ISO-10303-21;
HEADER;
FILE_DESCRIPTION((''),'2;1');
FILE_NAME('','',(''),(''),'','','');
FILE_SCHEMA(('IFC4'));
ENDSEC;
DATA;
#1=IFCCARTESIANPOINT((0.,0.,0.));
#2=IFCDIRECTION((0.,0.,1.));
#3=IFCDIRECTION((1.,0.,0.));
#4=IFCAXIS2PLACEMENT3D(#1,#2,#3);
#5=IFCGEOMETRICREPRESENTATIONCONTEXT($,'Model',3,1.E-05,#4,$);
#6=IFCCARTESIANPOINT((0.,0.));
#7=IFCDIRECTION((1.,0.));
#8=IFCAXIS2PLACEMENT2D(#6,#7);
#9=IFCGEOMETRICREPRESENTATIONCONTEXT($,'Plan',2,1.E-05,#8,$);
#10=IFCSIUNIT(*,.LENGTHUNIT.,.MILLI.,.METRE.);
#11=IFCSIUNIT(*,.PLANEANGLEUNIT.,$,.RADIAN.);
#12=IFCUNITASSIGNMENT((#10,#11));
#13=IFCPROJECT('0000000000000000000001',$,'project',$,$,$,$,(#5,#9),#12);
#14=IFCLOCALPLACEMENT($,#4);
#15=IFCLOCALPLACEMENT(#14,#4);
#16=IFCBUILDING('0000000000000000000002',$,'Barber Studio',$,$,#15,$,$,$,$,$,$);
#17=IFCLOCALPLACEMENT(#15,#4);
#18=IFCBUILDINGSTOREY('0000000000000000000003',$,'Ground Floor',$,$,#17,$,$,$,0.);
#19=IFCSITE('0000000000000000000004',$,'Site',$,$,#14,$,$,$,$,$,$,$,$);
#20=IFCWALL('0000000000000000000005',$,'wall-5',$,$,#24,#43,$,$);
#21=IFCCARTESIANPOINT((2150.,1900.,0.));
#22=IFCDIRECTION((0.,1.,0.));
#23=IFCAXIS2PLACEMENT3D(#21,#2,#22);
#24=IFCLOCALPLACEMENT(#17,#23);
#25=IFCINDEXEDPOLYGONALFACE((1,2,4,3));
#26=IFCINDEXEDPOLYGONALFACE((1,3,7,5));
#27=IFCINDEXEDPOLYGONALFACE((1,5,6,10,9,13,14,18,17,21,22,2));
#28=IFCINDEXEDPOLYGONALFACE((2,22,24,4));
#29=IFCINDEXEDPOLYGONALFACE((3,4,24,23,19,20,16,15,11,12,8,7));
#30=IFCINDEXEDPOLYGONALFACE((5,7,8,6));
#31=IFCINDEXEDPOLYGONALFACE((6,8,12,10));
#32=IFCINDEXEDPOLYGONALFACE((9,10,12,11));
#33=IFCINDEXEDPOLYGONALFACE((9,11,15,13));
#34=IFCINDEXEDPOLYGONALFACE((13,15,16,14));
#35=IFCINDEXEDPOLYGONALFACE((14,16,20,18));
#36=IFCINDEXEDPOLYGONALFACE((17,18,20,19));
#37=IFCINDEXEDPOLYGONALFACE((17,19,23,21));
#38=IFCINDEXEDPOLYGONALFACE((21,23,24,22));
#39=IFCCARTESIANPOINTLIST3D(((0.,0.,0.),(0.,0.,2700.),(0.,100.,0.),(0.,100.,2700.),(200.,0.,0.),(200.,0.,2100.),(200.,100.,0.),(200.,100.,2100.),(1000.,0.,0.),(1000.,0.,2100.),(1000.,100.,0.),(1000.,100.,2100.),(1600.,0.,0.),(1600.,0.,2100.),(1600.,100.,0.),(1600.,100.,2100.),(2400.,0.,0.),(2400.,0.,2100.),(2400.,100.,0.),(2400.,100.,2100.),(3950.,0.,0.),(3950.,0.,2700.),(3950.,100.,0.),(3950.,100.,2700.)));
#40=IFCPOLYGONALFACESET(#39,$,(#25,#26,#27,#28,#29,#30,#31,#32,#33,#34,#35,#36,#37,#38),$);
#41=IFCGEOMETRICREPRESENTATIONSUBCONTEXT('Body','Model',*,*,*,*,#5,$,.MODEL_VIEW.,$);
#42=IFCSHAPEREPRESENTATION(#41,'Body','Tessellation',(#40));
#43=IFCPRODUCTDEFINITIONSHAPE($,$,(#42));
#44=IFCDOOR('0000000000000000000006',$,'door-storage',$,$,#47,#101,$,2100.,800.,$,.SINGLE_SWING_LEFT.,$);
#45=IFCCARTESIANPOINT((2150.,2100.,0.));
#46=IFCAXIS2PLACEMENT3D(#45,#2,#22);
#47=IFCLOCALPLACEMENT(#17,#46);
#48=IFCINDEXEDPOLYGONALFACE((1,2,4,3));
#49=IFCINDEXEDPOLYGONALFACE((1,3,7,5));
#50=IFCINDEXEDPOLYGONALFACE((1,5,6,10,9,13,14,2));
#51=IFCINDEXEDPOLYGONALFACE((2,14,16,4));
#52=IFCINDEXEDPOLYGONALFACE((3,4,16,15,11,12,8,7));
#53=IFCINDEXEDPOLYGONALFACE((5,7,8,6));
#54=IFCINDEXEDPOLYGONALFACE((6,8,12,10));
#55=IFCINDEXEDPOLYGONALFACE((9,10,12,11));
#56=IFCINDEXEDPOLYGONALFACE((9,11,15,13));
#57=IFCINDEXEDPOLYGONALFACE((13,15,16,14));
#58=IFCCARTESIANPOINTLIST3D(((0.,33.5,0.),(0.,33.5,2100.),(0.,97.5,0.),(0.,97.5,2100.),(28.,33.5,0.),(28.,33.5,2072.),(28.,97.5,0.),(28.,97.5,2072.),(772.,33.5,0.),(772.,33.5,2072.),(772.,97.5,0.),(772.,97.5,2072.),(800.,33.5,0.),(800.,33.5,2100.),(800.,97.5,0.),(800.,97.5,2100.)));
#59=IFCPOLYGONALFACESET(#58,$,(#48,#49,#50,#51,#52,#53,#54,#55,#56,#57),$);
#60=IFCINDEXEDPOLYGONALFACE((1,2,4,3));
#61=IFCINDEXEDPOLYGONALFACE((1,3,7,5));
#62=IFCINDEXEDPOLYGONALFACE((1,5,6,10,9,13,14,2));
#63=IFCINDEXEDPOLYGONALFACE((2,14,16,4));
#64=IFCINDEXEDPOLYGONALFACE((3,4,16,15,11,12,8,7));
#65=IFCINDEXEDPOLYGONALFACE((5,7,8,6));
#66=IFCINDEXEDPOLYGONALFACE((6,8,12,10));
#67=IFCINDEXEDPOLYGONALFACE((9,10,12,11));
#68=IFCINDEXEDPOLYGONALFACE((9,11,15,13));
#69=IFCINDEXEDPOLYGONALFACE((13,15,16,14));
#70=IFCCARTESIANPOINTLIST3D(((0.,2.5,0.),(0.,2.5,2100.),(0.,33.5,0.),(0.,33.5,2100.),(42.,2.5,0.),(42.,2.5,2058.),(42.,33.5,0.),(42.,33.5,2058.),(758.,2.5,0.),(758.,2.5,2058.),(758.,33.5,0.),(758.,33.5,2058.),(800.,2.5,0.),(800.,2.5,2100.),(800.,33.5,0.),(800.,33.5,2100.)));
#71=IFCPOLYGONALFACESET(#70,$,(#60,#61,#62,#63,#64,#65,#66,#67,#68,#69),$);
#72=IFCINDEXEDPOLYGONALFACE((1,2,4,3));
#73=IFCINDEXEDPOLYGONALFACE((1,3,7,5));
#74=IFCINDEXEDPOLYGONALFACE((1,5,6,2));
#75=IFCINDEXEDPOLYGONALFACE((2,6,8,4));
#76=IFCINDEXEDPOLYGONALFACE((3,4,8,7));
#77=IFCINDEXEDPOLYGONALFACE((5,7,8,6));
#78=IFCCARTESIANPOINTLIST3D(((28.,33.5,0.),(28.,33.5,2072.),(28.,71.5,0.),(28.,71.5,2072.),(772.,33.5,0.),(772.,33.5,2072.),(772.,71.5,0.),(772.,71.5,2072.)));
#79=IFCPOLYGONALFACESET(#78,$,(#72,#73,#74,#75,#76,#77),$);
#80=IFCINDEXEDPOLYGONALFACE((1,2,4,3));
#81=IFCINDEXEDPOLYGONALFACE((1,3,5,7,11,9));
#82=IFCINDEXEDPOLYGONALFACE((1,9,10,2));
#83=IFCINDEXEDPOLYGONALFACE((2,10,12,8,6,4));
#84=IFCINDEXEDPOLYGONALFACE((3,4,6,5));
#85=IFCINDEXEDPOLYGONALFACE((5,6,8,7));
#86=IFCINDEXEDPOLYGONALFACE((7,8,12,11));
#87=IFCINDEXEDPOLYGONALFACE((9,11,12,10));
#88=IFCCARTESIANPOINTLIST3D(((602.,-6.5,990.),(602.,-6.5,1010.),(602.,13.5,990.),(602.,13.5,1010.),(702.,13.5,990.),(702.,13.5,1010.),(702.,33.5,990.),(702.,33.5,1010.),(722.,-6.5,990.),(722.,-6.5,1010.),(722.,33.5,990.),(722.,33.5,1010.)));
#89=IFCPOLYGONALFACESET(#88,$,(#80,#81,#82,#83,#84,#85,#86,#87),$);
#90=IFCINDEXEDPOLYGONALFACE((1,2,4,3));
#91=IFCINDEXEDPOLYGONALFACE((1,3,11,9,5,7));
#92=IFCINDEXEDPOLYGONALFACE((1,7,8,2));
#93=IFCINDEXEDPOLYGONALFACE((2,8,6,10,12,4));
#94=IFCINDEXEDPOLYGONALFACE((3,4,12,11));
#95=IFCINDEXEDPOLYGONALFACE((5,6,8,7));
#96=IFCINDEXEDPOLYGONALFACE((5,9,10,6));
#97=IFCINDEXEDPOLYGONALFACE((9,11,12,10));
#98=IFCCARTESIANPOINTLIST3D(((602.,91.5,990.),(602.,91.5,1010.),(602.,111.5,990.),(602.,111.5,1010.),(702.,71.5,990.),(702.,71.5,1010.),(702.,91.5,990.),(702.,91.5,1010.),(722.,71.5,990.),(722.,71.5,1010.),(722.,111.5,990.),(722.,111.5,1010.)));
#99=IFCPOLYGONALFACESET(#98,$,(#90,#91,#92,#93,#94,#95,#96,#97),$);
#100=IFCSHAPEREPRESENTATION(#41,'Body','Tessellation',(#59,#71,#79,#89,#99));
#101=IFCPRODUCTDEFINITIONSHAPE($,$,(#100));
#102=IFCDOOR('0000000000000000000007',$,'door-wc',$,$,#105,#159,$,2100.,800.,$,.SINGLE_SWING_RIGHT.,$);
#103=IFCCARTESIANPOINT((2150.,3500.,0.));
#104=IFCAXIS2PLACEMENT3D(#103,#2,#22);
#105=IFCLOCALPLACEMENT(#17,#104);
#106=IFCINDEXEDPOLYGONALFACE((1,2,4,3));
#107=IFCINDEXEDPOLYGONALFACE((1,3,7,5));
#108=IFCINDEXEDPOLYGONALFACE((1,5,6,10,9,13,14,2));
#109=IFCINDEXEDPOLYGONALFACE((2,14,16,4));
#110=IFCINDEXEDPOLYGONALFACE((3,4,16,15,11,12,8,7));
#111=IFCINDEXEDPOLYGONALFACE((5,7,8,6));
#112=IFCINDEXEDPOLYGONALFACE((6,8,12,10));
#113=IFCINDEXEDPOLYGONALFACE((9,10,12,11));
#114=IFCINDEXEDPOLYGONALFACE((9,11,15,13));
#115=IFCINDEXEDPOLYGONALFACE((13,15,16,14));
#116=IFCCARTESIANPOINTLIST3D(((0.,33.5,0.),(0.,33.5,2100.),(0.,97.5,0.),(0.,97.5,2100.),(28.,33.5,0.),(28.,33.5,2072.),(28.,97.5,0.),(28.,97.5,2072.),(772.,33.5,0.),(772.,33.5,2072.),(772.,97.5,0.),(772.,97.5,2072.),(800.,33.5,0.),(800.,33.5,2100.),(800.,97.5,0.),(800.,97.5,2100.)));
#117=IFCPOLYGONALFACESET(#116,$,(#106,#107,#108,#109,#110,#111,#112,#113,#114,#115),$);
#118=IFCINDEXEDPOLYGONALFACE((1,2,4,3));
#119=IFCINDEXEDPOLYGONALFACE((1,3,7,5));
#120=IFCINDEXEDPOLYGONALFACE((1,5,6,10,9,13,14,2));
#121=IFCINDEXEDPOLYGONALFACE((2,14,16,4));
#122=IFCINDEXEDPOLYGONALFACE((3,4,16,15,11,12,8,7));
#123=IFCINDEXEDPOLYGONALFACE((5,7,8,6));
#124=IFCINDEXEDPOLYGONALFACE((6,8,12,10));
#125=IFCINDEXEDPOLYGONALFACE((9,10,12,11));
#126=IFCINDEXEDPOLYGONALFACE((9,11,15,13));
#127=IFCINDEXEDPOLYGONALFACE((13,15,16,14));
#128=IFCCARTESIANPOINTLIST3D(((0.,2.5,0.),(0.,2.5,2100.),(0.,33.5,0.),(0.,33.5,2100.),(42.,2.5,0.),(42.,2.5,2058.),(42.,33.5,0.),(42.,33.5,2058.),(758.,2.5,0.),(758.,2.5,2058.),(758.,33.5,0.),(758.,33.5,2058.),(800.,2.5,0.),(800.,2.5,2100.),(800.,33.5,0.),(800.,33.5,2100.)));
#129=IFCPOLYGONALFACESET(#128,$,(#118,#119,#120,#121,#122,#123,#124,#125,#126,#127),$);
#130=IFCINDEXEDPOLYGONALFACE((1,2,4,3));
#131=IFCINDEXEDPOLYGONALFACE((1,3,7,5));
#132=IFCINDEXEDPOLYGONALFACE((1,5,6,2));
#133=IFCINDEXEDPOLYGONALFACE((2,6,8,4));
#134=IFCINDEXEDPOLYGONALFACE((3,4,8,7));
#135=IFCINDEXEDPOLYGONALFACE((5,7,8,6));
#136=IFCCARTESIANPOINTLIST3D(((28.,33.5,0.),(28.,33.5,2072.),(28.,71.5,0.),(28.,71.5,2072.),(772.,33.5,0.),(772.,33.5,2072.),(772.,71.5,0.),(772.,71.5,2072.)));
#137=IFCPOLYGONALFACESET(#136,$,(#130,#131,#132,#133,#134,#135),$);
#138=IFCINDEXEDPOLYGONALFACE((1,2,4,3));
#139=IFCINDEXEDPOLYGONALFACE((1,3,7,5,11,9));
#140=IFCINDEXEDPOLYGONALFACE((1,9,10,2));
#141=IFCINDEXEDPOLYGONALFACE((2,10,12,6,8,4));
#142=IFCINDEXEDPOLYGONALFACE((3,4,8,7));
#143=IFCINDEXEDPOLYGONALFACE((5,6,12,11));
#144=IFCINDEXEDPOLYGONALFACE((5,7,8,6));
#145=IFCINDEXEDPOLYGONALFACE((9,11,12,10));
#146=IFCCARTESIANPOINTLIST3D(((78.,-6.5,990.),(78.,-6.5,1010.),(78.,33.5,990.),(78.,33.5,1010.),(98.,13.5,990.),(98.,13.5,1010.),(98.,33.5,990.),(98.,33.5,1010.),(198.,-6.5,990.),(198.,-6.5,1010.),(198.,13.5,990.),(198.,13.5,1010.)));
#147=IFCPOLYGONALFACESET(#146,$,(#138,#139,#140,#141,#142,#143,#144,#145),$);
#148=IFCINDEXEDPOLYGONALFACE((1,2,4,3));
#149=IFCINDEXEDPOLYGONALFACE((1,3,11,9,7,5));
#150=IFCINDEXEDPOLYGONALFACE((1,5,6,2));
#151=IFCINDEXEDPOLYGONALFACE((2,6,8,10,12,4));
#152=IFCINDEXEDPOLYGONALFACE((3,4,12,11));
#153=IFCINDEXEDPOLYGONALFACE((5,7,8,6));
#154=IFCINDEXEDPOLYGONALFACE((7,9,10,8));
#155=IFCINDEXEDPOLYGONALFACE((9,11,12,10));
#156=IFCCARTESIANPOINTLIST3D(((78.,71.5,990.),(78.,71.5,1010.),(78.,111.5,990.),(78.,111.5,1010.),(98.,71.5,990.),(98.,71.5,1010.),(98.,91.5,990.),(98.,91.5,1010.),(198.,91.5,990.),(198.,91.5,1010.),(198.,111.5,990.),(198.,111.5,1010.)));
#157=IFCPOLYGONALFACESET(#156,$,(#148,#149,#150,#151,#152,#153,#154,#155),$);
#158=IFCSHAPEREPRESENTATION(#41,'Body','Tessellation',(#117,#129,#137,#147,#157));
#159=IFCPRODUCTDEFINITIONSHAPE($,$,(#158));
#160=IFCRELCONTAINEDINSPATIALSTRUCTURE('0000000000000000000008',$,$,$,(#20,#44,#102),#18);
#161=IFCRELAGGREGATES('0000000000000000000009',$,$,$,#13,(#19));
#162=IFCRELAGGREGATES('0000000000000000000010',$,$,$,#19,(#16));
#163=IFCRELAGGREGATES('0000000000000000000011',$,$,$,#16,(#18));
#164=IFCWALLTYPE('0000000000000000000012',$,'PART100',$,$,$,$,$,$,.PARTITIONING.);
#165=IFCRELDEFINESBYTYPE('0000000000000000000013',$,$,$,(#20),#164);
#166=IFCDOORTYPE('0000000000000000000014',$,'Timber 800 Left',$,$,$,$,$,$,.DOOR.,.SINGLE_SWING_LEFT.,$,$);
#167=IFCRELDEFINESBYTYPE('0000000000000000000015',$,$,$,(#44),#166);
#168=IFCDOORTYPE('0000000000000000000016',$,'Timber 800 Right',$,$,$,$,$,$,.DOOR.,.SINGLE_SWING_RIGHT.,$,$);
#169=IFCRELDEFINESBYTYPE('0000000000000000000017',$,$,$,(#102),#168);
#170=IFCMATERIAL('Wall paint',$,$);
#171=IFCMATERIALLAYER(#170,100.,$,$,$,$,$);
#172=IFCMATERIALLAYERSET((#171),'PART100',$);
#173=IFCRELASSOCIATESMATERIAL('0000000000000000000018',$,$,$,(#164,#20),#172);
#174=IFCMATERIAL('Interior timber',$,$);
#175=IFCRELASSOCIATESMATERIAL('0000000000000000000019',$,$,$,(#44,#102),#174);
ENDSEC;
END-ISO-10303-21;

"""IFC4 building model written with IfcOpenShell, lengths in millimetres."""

from ifc_helpers import new_model, entity, si_unit, frame, origin_with_axes, origin_2d_with_axis, place, context, subcontext, project, spatial, line, indexed_curve, outline, extrude, shape, material, layer, layer_set, layer_usage, type_object, element, fill, save


model = new_model("IFC4")

# Units and contexts
model_context = context("Model", 3, precision=1e-05, world=origin_with_axes())
plan_context = context("Plan", 2, precision=1e-05, world=origin_2d_with_axis())
body_context_1 = subcontext(model_context, "Body", "Model", "MODEL_VIEW")
body_context_2 = subcontext(plan_context, "Body", "Plan", "PLAN_VIEW")
ifc_project = project(units=[si_unit("LENGTHUNIT", "METRE", prefix="MILLI"), si_unit("PLANEANGLEUNIT", "RADIAN")], contexts=[model_context, plan_context])

# Site, building, storey
site_placement = place(None, origin_with_axes())
site = spatial("IfcSite", under=ifc_project, at=site_placement, Name="Site")
building_placement = place(site_placement, origin_with_axes())
building = spatial("IfcBuilding", under=site, at=building_placement, Name="Barber Studio")
storey_placement = place(building_placement, origin_with_axes())
storey = spatial("IfcBuildingStorey", under=building, at=storey_placement, Name="Ground Floor", Elevation=0.0)

# Wall, openings, doors
ifc_material_1 = material(Name="Wall paint")
ifc_layer_1 = layer(ifc_material_1, 100.0)
ifc_layer_set_1 = layer_set([ifc_layer_1], Name="PART100")
ifc_layer_usage_1 = layer_usage(ifc_layer_set_1, "AXIS2", "POSITIVE", 0.0)
wall_type_1 = type_object("IfcWallType", Name="PART100", PredefinedType="PARTITIONING", material=ifc_layer_set_1)
wall_1_placement = place(storey_placement, frame((2150.0, 1900.0, 0.0), z_axis=(0.0, 0.0, 1.0), x_axis=(0.0, 1.0, 0.0)))
wall_1 = element("IfcWall", 1, at=wall_1_placement, inside=storey, type_object=wall_type_1, material=ifc_layer_usage_1, Name="wall-5", context=body_context_1, shape_type="SweptSolid", body=[
    extrude(outline(indexed_curve([(0.0, 0.0), (0.0, 100.0), (3950.0, 100.0), (3950.0, 0.0), (0.0, 0.0)], self_intersect=False)), origin_with_axes(), (0.0, 0.0, 1.0), 2700.0),
])
opening_1_placement = place(wall_1_placement, frame((200.0, 0.0, 0.0), z_axis=(0.0, 0.0, 1.0), x_axis=(1.0, 0.0, 0.0)))
opening_1 = element("IfcOpeningElement", 2, at=opening_1_placement, cuts=wall_1, PredefinedType="OPENING", context=body_context_1, shape_type="SweptSolid", body=[
    extrude(outline(indexed_curve([(0.0, 0.0), (800.0, 0.0), (800.0, 130.0), (0.0, 130.0)], segments=[line(1, 2, 3, 4, 1)])), frame((0.0, -15.0, 0.0), z_axis=(0.0, 0.0, 1.0), x_axis=(1.0, 0.0, 0.0)), (0.0, 0.0, 1.0), 2100.0),
])
opening_2_placement = place(wall_1_placement, frame((1600.0, 0.0, 0.0), z_axis=(0.0, 0.0, 1.0), x_axis=(1.0, 0.0, 0.0)))
opening_2 = element("IfcOpeningElement", 3, at=opening_2_placement, cuts=wall_1, PredefinedType="OPENING", context=body_context_1, shape_type="SweptSolid", body=[
    extrude(outline(indexed_curve([(0.0, 0.0), (800.0, 0.0), (800.0, 130.0), (0.0, 130.0)], segments=[line(1, 2, 3, 4, 1)])), frame((0.0, -15.0, 0.0), z_axis=(0.0, 0.0, 1.0), x_axis=(1.0, 0.0, 0.0)), (0.0, 0.0, 1.0), 2100.0),
])
ifc_material_2 = material(Name="Interior timber")
door_type_1 = type_object("IfcDoorType", Name="Timber 800 Left", OperationType="SINGLE_SWING_LEFT", PredefinedType="DOOR")
door_1_placement = place(storey_placement, frame((2150.0, 2100.0, 0.0), z_axis=(0.0, 0.0, 1.0), x_axis=(0.0, 1.0, 0.0)))
door_1 = element("IfcDoor", 4, at=door_1_placement, inside=storey, type_object=door_type_1, material=ifc_material_2, Name="door-storage", OperationType="SINGLE_SWING_LEFT", OverallHeight=2100.0, OverallWidth=800.0, shapes=[
    shape(body_context_1, "Body", "SweptSolid", [extrude(outline(indexed_curve([(0.0, 0.0), (0.0, 2100.0), (800.0, 2100.0), (800.0, 0.0), (772.0, 0.0), (772.0, 2072.0), (28.0, 2072.0), (28.0, 0.0)], segments=[line(1, 2, 3, 4, 5, 6, 7, 8, 1)])), frame((0.0, 33.5, 0.0), z_axis=(0.0, -1.0, 0.0), x_axis=(1.0, 0.0, 0.0)), (0.0, 0.0, -1.0), 64.0), extrude(outline(indexed_curve([(0.0, 0.0), (0.0, 2100.0), (800.0, 2100.0), (800.0, 0.0), (758.0, 0.0), (758.0, 2058.0), (42.0, 2058.0), (42.0, 0.0)], segments=[line(1, 2, 3, 4, 5, 6, 7, 8, 1)])), frame((0.0, 2.5, 0.0), z_axis=(0.0, -1.0, 0.0), x_axis=(1.0, 0.0, 0.0)), (0.0, 0.0, -1.0), 31.0), extrude(outline(indexed_curve([(0.0, 0.0), (744.0, 0.0), (744.0, 38.0), (0.0, 38.0)], segments=[line(1, 2, 3, 4, 1)])), frame((28.0, 33.5, 0.0), z_axis=(0.0, 0.0, 1.0), x_axis=(1.0, 0.0, 0.0)), (0.0, 0.0, 1.0), 2072.0), extrude(outline(indexed_curve([(0.0, 0.0), (0.0, -40.0), (-120.0, -40.0), (-120.0, -20.0), (-20.0, -20.0), (-20.0, 0.0)], segments=[line(1, 2, 3, 4, 5, 6, 1)])), frame((722.0, 33.5, 990.0), z_axis=(0.0, 0.0, 1.0), x_axis=(1.0, 0.0, 0.0)), (0.0, 0.0, 1.0), 20.0), extrude(outline(indexed_curve([(0.0, 0.0), (0.0, 40.0), (-120.0, 40.0), (-120.0, 20.0), (-20.0, 20.0), (-20.0, 0.0)], segments=[line(1, 2, 3, 4, 5, 6, 1)])), frame((722.0, 71.5, 990.0), z_axis=(0.0, 0.0, 1.0), x_axis=(1.0, 0.0, 0.0)), (0.0, 0.0, 1.0), 20.0)]),
    shape(body_context_2, "Body", "Curve2D", [entity("IfcIndexedPolyCurve", entity("IfcCartesianPointList2D", [[0.0, 2.5], [0.0, 97.5], [28.0, 97.5], [28.0, 33.5], [42.0, 33.5], [42.0, 2.5]]), [entity("IfcLineIndex", [1, 2, 3, 4, 5, 6, 1])]), entity("IfcIndexedPolyCurve", entity("IfcCartesianPointList2D", [[800.0, 2.5], [800.0, 97.5], [772.0, 97.5], [772.0, 33.5], [758.0, 33.5], [758.0, 2.5]]), [entity("IfcLineIndex", [1, 2, 3, 4, 5, 6, 1])]), entity("IfcTrimmedCurve", entity("IfcEllipse", entity("IfcAxis2Placement2D", entity("IfcCartesianPoint", [66.0, 97.5]), entity("IfcDirection", [1.0, 0.0])), 706.0, 744.0), [entity("IfcCartesianPoint", [772.0, 97.5])], [entity("IfcCartesianPoint", [66.0, 841.5])], True, "CARTESIAN"), entity("IfcIndexedPolyCurve", entity("IfcCartesianPointList2D", [[28.0, 97.5], [66.0, 97.5], [66.0, 841.5], [28.0, 841.5]]), [entity("IfcLineIndex", [1, 2, 3, 4, 1])])]),
])
fill(opening_1, door_1)
door_type_2 = type_object("IfcDoorType", Name="Timber 800 Right", OperationType="SINGLE_SWING_RIGHT", PredefinedType="DOOR")
door_2_placement = place(storey_placement, frame((2150.0, 3500.0, 0.0), z_axis=(0.0, 0.0, 1.0), x_axis=(0.0, 1.0, 0.0)))
door_2 = element("IfcDoor", 5, at=door_2_placement, inside=storey, type_object=door_type_2, material=ifc_material_2, Name="door-wc", OperationType="SINGLE_SWING_RIGHT", OverallHeight=2100.0, OverallWidth=800.0, shapes=[
    shape(body_context_1, "Body", "SweptSolid", [extrude(outline(indexed_curve([(0.0, 0.0), (0.0, 2100.0), (800.0, 2100.0), (800.0, 0.0), (772.0, 0.0), (772.0, 2072.0), (28.0, 2072.0), (28.0, 0.0)], segments=[line(1, 2, 3, 4, 5, 6, 7, 8, 1)])), frame((0.0, 33.5, 0.0), z_axis=(0.0, -1.0, 0.0), x_axis=(1.0, 0.0, 0.0)), (0.0, 0.0, -1.0), 64.0), extrude(outline(indexed_curve([(0.0, 0.0), (0.0, 2100.0), (800.0, 2100.0), (800.0, 0.0), (758.0, 0.0), (758.0, 2058.0), (42.0, 2058.0), (42.0, 0.0)], segments=[line(1, 2, 3, 4, 5, 6, 7, 8, 1)])), frame((0.0, 2.5, 0.0), z_axis=(0.0, -1.0, 0.0), x_axis=(1.0, 0.0, 0.0)), (0.0, 0.0, -1.0), 31.0), extrude(outline(indexed_curve([(0.0, 0.0), (744.0, 0.0), (744.0, 38.0), (0.0, 38.0)], segments=[line(1, 2, 3, 4, 1)])), frame((28.0, 33.5, 0.0), z_axis=(0.0, 0.0, 1.0), x_axis=(1.0, 0.0, 0.0)), (0.0, 0.0, 1.0), 2072.0), extrude(outline(indexed_curve([(0.0, 0.0), (0.0, -40.0), (120.0, -40.0), (120.0, -20.0), (20.0, -20.0), (20.0, 0.0)], segments=[line(1, 2, 3, 4, 5, 6, 1)])), frame((78.0, 33.5, 990.0), z_axis=(0.0, 0.0, 1.0), x_axis=(1.0, 0.0, 0.0)), (0.0, 0.0, 1.0), 20.0), extrude(outline(indexed_curve([(0.0, 0.0), (0.0, 40.0), (120.0, 40.0), (120.0, 20.0), (20.0, 20.0), (20.0, 0.0)], segments=[line(1, 2, 3, 4, 5, 6, 1)])), frame((78.0, 71.5, 990.0), z_axis=(0.0, 0.0, 1.0), x_axis=(1.0, 0.0, 0.0)), (0.0, 0.0, 1.0), 20.0)]),
    shape(body_context_2, "Body", "Curve2D", [entity("IfcIndexedPolyCurve", entity("IfcCartesianPointList2D", [[0.0, 2.5], [0.0, 97.5], [28.0, 97.5], [28.0, 33.5], [42.0, 33.5], [42.0, 2.5]]), [entity("IfcLineIndex", [1, 2, 3, 4, 5, 6, 1])]), entity("IfcIndexedPolyCurve", entity("IfcCartesianPointList2D", [[800.0, 2.5], [800.0, 97.5], [772.0, 97.5], [772.0, 33.5], [758.0, 33.5], [758.0, 2.5]]), [entity("IfcLineIndex", [1, 2, 3, 4, 5, 6, 1])]), entity("IfcTrimmedCurve", entity("IfcEllipse", entity("IfcAxis2Placement2D", entity("IfcCartesianPoint", [734.0, 97.5]), entity("IfcDirection", [1.0, 0.0])), 706.0, 744.0), [entity("IfcCartesianPoint", [734.0, 841.5])], [entity("IfcCartesianPoint", [28.0, 97.5])], True, "CARTESIAN"), entity("IfcIndexedPolyCurve", entity("IfcCartesianPointList2D", [[772.0, 97.5], [734.0, 97.5], [734.0, 841.5], [772.0, 841.5]]), [entity("IfcLineIndex", [1, 2, 3, 4, 1])])]),
])
fill(opening_2, door_2)

save(model, "model.ifc")
